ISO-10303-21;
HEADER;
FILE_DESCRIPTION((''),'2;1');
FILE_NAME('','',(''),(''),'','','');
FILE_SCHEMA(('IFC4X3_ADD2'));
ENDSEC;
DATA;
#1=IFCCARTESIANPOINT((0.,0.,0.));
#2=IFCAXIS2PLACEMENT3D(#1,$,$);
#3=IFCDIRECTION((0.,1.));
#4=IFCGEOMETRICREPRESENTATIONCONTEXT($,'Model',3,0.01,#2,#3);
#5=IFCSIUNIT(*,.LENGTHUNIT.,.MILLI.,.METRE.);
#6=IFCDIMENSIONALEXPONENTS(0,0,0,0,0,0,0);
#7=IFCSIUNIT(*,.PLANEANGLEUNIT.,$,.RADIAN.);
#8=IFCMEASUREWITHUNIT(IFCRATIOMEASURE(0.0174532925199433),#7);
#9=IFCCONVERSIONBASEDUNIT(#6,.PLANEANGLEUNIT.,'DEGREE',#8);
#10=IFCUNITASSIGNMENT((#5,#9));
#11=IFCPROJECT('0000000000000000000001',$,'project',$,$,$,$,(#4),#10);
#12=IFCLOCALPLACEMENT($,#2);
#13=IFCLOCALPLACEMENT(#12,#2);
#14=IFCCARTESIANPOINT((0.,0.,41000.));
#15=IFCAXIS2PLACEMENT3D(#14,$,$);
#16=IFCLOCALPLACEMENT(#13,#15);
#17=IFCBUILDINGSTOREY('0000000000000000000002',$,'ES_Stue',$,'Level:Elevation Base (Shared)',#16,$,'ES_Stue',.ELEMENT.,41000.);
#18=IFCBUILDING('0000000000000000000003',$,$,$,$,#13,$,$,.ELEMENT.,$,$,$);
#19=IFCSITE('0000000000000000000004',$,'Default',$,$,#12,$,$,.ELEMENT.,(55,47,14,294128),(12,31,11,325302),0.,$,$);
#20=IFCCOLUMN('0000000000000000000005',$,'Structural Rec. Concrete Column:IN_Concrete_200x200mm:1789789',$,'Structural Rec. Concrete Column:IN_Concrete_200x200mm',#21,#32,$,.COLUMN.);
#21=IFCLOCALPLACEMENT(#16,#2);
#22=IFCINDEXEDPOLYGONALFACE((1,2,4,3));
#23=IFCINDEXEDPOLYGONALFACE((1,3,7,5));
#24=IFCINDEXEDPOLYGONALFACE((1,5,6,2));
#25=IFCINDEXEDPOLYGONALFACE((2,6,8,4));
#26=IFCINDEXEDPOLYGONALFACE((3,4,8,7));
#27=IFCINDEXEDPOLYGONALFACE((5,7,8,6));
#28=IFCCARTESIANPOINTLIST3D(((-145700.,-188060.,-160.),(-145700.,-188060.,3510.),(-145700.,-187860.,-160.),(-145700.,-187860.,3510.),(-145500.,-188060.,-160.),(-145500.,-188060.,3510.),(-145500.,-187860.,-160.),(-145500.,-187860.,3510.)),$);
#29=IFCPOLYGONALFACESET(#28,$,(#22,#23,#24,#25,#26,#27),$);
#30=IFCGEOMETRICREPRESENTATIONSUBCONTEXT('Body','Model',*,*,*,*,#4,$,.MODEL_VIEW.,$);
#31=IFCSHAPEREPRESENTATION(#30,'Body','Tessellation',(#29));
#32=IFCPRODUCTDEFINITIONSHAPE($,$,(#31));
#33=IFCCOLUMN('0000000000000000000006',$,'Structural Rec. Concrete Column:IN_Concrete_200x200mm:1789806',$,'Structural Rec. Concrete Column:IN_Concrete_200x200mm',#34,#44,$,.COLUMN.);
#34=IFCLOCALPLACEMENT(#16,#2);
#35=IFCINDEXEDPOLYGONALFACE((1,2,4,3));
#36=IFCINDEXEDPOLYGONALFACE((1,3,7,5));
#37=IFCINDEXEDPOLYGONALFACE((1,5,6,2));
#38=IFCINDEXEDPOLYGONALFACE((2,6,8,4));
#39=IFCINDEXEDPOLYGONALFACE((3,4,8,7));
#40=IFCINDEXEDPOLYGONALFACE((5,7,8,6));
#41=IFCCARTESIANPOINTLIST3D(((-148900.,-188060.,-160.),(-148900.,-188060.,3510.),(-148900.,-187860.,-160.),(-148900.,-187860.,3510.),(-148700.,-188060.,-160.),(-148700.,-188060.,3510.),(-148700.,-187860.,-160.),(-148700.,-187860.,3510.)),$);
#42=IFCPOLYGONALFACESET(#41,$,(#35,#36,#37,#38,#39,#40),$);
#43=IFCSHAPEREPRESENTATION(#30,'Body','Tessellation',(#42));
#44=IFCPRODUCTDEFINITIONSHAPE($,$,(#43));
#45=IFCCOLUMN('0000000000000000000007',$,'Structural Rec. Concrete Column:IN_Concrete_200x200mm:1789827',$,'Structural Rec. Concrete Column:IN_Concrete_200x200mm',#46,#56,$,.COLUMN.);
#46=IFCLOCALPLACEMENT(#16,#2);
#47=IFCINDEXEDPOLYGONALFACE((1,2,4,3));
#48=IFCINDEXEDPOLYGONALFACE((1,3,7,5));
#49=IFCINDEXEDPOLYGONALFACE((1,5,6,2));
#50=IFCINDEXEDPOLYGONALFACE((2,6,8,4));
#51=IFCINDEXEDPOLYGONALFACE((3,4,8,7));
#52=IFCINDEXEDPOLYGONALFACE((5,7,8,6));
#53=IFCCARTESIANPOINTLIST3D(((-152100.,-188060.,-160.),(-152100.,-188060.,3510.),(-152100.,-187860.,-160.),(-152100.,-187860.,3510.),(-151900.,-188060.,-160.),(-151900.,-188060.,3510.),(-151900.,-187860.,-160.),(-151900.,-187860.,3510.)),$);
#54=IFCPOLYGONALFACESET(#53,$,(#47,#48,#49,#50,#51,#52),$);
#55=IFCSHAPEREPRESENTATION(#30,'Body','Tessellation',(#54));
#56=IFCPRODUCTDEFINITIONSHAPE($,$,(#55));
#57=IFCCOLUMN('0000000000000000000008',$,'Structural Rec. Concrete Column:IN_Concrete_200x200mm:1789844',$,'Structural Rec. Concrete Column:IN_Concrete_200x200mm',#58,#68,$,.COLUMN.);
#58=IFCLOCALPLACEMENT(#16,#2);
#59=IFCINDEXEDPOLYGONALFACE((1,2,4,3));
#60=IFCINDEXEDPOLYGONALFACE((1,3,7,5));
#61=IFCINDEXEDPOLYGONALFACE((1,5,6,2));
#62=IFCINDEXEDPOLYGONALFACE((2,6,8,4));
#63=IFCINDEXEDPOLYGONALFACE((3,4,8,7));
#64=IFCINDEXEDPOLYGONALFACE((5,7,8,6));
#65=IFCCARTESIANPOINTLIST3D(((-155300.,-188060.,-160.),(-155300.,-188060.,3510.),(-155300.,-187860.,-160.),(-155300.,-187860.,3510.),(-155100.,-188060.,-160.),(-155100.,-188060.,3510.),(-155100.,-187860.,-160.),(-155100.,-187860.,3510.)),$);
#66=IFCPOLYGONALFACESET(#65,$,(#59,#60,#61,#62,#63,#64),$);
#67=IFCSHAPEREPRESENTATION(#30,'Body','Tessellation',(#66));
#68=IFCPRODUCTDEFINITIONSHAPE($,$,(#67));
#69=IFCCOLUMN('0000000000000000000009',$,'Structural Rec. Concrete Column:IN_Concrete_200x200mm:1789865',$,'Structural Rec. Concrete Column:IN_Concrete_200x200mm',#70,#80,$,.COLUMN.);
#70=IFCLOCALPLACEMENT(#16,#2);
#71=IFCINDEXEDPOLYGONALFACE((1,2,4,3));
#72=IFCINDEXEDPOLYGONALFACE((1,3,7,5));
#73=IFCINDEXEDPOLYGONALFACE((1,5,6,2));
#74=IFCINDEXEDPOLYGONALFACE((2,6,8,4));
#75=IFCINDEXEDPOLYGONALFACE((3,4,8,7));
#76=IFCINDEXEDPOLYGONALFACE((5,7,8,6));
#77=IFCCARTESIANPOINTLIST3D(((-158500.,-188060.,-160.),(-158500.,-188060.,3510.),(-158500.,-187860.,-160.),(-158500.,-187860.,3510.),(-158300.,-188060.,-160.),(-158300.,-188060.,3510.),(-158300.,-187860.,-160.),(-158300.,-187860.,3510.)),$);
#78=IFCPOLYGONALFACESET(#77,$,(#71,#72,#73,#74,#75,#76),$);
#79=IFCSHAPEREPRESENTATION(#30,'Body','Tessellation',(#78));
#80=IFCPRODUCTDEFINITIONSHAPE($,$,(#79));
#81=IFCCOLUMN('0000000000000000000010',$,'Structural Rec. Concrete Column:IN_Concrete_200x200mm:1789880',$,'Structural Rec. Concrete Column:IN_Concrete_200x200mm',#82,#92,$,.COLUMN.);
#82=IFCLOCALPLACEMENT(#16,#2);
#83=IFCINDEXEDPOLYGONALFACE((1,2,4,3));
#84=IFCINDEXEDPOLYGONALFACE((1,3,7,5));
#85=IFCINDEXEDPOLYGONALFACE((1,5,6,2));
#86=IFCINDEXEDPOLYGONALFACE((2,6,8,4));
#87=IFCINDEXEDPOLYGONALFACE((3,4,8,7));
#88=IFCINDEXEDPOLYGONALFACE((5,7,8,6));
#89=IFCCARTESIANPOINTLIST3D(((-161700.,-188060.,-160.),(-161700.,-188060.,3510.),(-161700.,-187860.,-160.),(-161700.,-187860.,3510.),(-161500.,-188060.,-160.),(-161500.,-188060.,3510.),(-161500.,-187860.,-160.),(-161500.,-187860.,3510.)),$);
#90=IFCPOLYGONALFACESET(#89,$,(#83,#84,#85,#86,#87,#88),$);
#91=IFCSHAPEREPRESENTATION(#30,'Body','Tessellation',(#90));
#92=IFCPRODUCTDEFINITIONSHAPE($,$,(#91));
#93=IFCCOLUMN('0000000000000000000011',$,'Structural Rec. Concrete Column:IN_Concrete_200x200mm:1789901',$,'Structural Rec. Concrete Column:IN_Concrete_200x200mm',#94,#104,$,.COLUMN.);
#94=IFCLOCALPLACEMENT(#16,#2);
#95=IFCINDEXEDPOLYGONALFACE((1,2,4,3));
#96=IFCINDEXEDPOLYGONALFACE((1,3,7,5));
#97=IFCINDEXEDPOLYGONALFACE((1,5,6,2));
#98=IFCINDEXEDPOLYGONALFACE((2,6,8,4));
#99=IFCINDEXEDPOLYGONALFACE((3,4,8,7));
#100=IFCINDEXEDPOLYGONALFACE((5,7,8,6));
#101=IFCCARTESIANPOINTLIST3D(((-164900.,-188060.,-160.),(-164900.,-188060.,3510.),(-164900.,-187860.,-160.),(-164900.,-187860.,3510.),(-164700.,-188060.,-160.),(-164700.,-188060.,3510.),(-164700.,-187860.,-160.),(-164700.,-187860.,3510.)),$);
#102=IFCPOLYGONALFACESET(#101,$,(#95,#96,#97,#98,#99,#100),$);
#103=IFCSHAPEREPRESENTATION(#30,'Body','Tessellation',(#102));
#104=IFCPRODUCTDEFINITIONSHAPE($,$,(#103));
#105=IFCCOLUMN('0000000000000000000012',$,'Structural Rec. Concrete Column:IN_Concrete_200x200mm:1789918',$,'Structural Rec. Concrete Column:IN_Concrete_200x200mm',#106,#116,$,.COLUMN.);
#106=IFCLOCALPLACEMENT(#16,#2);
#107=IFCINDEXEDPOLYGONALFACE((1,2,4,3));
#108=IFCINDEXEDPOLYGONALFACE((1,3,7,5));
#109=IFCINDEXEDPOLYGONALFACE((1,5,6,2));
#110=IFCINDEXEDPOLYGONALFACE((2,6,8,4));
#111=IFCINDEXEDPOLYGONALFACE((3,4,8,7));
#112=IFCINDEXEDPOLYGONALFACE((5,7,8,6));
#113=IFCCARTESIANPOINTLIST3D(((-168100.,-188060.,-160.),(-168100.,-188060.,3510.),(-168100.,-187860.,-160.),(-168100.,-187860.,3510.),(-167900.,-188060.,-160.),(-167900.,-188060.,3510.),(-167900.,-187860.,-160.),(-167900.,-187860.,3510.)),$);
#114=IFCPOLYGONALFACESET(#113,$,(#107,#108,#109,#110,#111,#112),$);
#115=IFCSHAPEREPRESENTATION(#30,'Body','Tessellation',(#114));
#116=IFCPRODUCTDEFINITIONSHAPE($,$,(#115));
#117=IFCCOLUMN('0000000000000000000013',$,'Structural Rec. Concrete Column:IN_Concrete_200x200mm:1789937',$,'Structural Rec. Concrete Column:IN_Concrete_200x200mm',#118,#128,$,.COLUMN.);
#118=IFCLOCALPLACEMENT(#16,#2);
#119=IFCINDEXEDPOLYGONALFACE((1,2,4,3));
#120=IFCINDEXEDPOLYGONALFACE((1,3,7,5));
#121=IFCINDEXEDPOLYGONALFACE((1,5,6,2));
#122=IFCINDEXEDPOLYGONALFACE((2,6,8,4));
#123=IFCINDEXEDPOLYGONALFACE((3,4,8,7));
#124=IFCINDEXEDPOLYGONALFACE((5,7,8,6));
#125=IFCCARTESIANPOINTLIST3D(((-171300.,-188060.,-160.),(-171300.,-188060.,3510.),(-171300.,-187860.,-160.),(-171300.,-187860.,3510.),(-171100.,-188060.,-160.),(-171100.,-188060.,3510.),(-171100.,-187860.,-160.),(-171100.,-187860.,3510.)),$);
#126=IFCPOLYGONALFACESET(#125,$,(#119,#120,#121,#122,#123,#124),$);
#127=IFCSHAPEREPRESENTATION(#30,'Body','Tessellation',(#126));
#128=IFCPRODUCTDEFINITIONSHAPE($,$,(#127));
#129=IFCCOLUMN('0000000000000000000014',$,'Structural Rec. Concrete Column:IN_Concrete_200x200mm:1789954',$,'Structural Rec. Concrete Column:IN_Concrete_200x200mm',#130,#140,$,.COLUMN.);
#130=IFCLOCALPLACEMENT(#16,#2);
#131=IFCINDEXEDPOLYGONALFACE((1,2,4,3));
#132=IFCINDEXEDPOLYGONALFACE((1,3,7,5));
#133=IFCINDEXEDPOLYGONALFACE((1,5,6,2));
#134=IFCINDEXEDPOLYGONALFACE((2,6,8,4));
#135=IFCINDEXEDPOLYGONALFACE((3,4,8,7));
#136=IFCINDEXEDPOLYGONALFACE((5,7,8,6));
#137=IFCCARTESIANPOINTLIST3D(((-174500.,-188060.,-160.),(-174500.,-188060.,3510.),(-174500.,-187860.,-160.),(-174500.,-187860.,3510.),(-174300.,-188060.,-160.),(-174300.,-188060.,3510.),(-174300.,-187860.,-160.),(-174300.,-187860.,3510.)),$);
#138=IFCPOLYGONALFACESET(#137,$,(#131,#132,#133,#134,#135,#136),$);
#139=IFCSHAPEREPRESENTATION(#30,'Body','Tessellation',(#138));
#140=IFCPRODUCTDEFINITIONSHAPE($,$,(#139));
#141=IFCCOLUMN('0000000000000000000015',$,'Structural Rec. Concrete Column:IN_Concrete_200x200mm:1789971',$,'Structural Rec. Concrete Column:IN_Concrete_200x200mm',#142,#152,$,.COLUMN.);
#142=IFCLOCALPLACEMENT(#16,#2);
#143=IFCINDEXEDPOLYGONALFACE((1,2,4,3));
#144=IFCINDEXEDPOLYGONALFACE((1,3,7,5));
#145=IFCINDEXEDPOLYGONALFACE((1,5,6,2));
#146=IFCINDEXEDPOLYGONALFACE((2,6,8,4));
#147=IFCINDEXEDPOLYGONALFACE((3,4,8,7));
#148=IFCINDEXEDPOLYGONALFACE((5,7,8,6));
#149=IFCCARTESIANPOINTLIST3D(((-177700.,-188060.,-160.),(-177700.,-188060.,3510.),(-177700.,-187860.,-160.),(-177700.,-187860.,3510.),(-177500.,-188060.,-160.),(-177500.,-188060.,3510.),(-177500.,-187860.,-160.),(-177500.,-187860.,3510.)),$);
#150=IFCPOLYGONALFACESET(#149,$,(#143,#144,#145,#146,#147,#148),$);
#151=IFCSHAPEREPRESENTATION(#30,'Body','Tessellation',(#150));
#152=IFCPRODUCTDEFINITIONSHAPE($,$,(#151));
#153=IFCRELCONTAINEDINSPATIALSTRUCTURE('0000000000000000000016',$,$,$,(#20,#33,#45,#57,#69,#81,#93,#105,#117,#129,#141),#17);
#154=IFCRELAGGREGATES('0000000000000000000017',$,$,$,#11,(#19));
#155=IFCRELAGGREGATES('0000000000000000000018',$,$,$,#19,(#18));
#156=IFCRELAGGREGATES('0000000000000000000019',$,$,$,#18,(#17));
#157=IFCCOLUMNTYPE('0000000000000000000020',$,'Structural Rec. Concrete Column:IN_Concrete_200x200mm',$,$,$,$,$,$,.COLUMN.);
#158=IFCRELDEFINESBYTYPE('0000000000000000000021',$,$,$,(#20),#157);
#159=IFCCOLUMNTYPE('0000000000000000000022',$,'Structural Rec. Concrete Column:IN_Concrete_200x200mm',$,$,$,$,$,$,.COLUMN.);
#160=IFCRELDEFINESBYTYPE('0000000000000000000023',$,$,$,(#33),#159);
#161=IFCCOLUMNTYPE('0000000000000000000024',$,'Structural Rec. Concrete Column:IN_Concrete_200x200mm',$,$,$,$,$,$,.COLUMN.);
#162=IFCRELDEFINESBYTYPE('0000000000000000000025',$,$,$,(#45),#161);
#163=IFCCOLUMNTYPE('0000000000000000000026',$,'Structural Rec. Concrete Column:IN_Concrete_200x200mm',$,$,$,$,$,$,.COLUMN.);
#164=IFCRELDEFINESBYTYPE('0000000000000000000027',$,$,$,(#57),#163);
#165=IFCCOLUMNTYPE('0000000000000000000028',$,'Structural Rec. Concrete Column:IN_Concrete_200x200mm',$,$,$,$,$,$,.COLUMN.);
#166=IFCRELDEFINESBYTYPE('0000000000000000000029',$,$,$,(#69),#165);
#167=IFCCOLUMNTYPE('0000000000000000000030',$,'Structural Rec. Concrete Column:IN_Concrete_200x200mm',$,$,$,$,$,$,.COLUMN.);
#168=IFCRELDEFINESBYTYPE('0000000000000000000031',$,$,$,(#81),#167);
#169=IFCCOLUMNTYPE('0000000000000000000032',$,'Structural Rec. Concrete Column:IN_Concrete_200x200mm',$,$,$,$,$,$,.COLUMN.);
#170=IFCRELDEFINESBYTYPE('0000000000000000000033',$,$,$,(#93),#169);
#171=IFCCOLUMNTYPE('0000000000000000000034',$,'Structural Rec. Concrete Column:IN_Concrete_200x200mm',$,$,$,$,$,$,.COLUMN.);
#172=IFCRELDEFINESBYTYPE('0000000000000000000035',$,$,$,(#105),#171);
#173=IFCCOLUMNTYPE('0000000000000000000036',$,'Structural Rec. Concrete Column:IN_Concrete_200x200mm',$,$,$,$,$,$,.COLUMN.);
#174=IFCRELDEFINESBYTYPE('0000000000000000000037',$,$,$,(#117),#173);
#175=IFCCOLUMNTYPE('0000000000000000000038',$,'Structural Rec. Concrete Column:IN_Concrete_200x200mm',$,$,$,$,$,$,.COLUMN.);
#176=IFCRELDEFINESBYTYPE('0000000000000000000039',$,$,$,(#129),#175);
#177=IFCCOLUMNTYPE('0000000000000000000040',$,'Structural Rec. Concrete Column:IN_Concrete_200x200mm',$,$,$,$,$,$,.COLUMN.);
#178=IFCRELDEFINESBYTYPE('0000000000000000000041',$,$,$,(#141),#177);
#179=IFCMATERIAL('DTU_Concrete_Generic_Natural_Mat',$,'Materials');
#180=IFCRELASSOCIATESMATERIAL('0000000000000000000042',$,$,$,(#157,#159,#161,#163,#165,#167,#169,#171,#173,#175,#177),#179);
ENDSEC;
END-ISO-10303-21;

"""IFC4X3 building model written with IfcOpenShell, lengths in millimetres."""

from ifc_helpers import new_model, entity, si_unit, converted_unit, direction, frame, frame_2d, origin, origin_2d_with_axis, place, context, subcontext, project, spatial, rectangle, extrude, source, transform, mapped, material, material_profile, profile_set, type_object, type_shapes, element, save


model = new_model("IFC4X3")

# Units and contexts
model_context = context("Model", 3, precision=0.01, world=origin(), true_north=direction((0.0, 1.0)))
body_context = subcontext(model_context, "Body", "Model", "MODEL_VIEW")
ifc_project = project(units=[si_unit("LENGTHUNIT", "METRE", prefix="MILLI"), converted_unit("PLANEANGLEUNIT", "DEGREE", entity("IfcRatioMeasure", 0.0174532925199433), si_unit("PLANEANGLEUNIT", "RADIAN"), dimensions=[0, 0, 0, 0, 0, 0, 0])], contexts=[model_context])

# Site, building, storey
site_placement = place(None, origin())
site = spatial("IfcSite", under=ifc_project, at=site_placement, Name="Default", CompositionType="ELEMENT", RefLatitude=(55, 47, 14, 294128), RefLongitude=(12, 31, 11, 325302), RefElevation=0.0)
building_placement = place(site_placement, origin())
building = spatial("IfcBuilding", under=site, at=building_placement, CompositionType="ELEMENT")
storey_placement = place(building_placement, frame((0.0, 0.0, 41000.0)))
storey = spatial("IfcBuildingStorey", under=building, at=storey_placement, Name="ES_Stue", ObjectType="Level:Elevation Base (Shared)", LongName="ES_Stue", CompositionType="ELEMENT", Elevation=41000.0)

# Columns
ifc_material = material(Name="DTU_Concrete_Generic_Natural_Mat", Category="Materials")
ifc_material_profile_1 = material_profile(ifc_material, rectangle(XDim=200.0, YDim=200.0, at=origin_2d_with_axis()), Name="IN_Concrete_200x200mm")
ifc_profile_set_1 = profile_set([ifc_material_profile_1], Name="IN_Concrete_200x200mm")
column_type_1 = type_object("IfcColumnType", Name="Structural Rec. Concrete Column:IN_Concrete_200x200mm", PredefinedType="COLUMN", material=ifc_profile_set_1)
shared_shape_1 = source(origin(), body_context, "Body", "SweptSolid", [
    extrude(rectangle(XDim=200.0, YDim=200.0, at=frame_2d((0.0, 0.0), x_axis=(1.0, 0.0))), frame((-145600.0, -187960.0, 40840.0), z_axis=(0.0, 0.0, 1.0), x_axis=(0.0, -1.0, 0.0)), (0.0, 0.0, 1.0), 3670.0),
])
type_shapes(column_type_1, [shared_shape_1])
column_1_placement = place(storey_placement, frame((0.0, 0.0, -41000.0)))
element("IfcColumn", 1, at=column_1_placement, inside=storey, type_object=column_type_1, Name="Structural Rec. Concrete Column:IN_Concrete_200x200mm:1789789", ObjectType="Structural Rec. Concrete Column:IN_Concrete_200x200mm", PredefinedType="COLUMN", context=body_context, shape_type="MappedRepresentation", body=[
    mapped(shared_shape_1, transform((0.0, 0.0, 0.0), scale=1.0)),
])
column_type_2 = type_object("IfcColumnType", Name="Structural Rec. Concrete Column:IN_Concrete_200x200mm", PredefinedType="COLUMN", material=ifc_profile_set_1)
shared_shape_2 = source(origin(), body_context, "Body", "SweptSolid", [
    extrude(rectangle(XDim=200.0, YDim=200.0, at=origin_2d_with_axis()), frame((-148800.0, -187960.0, 40840.0), z_axis=(0.0, 0.0, 1.0), x_axis=(0.0, -1.0, 0.0)), (0.0, 0.0, 1.0), 3670.0),
])
type_shapes(column_type_2, [shared_shape_2])
column_2_placement = place(storey_placement, frame((0.0, 0.0, -41000.0)))
element("IfcColumn", 2, at=column_2_placement, inside=storey, type_object=column_type_2, Name="Structural Rec. Concrete Column:IN_Concrete_200x200mm:1789806", ObjectType="Structural Rec. Concrete Column:IN_Concrete_200x200mm", PredefinedType="COLUMN", context=body_context, shape_type="MappedRepresentation", body=[
    mapped(shared_shape_2, transform((0.0, 0.0, 0.0), scale=1.0)),
])
column_type_3 = type_object("IfcColumnType", Name="Structural Rec. Concrete Column:IN_Concrete_200x200mm", PredefinedType="COLUMN", material=ifc_profile_set_1)
shared_shape_3 = source(origin(), body_context, "Body", "SweptSolid", [
    extrude(rectangle(XDim=200.0, YDim=200.0, at=frame_2d((0.0, 0.0), x_axis=(1.0, 0.0))), frame((-152000.0, -187960.0, 40840.0), z_axis=(0.0, 0.0, 1.0), x_axis=(0.0, -1.0, 0.0)), (0.0, 0.0, 1.0), 3670.0),
])
type_shapes(column_type_3, [shared_shape_3])
column_3_placement = place(storey_placement, frame((0.0, 0.0, -41000.0)))
element("IfcColumn", 3, at=column_3_placement, inside=storey, type_object=column_type_3, Name="Structural Rec. Concrete Column:IN_Concrete_200x200mm:1789827", ObjectType="Structural Rec. Concrete Column:IN_Concrete_200x200mm", PredefinedType="COLUMN", context=body_context, shape_type="MappedRepresentation", body=[
    mapped(shared_shape_3, transform((0.0, 0.0, 0.0), scale=1.0)),
])
column_type_4 = type_object("IfcColumnType", Name="Structural Rec. Concrete Column:IN_Concrete_200x200mm", PredefinedType="COLUMN", material=ifc_profile_set_1)
shared_shape_4 = source(origin(), body_context, "Body", "SweptSolid", [
    extrude(rectangle(XDim=200.0, YDim=200.0, at=origin_2d_with_axis()), frame((-155200.0, -187960.0, 40840.0), z_axis=(0.0, 0.0, 1.0), x_axis=(0.0, -1.0, 0.0)), (0.0, 0.0, 1.0), 3670.0),
])
type_shapes(column_type_4, [shared_shape_4])
column_4_placement = place(storey_placement, frame((0.0, 0.0, -41000.0)))
element("IfcColumn", 4, at=column_4_placement, inside=storey, type_object=column_type_4, Name="Structural Rec. Concrete Column:IN_Concrete_200x200mm:1789844", ObjectType="Structural Rec. Concrete Column:IN_Concrete_200x200mm", PredefinedType="COLUMN", context=body_context, shape_type="MappedRepresentation", body=[
    mapped(shared_shape_4, transform((0.0, 0.0, 0.0), scale=1.0)),
])
column_type_5 = type_object("IfcColumnType", Name="Structural Rec. Concrete Column:IN_Concrete_200x200mm", PredefinedType="COLUMN", material=ifc_profile_set_1)
shared_shape_5 = source(origin(), body_context, "Body", "SweptSolid", [
    extrude(rectangle(XDim=200.0, YDim=200.0, at=origin_2d_with_axis()), frame((-158400.0, -187960.0, 40840.0), z_axis=(0.0, 0.0, 1.0), x_axis=(0.0, -1.0, 0.0)), (0.0, 0.0, 1.0), 3670.0),
])
type_shapes(column_type_5, [shared_shape_5])
column_5_placement = place(storey_placement, frame((0.0, 0.0, -41000.0)))
element("IfcColumn", 5, at=column_5_placement, inside=storey, type_object=column_type_5, Name="Structural Rec. Concrete Column:IN_Concrete_200x200mm:1789865", ObjectType="Structural Rec. Concrete Column:IN_Concrete_200x200mm", PredefinedType="COLUMN", context=body_context, shape_type="MappedRepresentation", body=[
    mapped(shared_shape_5, transform((0.0, 0.0, 0.0), scale=1.0)),
])
column_type_6 = type_object("IfcColumnType", Name="Structural Rec. Concrete Column:IN_Concrete_200x200mm", PredefinedType="COLUMN", material=ifc_profile_set_1)
shared_shape_6 = source(origin(), body_context, "Body", "SweptSolid", [
    extrude(rectangle(XDim=200.0, YDim=200.0, at=origin_2d_with_axis()), frame((-161600.0, -187960.0, 40840.0), z_axis=(0.0, 0.0, 1.0), x_axis=(0.0, -1.0, 0.0)), (0.0, 0.0, 1.0), 3670.0),
])
type_shapes(column_type_6, [shared_shape_6])
column_6_placement = place(storey_placement, frame((0.0, 0.0, -41000.0)))
element("IfcColumn", 6, at=column_6_placement, inside=storey, type_object=column_type_6, Name="Structural Rec. Concrete Column:IN_Concrete_200x200mm:1789880", ObjectType="Structural Rec. Concrete Column:IN_Concrete_200x200mm", PredefinedType="COLUMN", context=body_context, shape_type="MappedRepresentation", body=[
    mapped(shared_shape_6, transform((0.0, 0.0, 0.0), scale=1.0)),
])
column_type_7 = type_object("IfcColumnType", Name="Structural Rec. Concrete Column:IN_Concrete_200x200mm", PredefinedType="COLUMN", material=ifc_profile_set_1)
shared_shape_7 = source(origin(), body_context, "Body", "SweptSolid", [
    extrude(rectangle(XDim=200.0, YDim=200.0, at=origin_2d_with_axis()), frame((-164800.0, -187960.0, 40840.0), z_axis=(0.0, 0.0, 1.0), x_axis=(0.0, -1.0, 0.0)), (0.0, 0.0, 1.0), 3670.0),
])
type_shapes(column_type_7, [shared_shape_7])
column_7_placement = place(storey_placement, frame((0.0, 0.0, -41000.0)))
element("IfcColumn", 7, at=column_7_placement, inside=storey, type_object=column_type_7, Name="Structural Rec. Concrete Column:IN_Concrete_200x200mm:1789901", ObjectType="Structural Rec. Concrete Column:IN_Concrete_200x200mm", PredefinedType="COLUMN", context=body_context, shape_type="MappedRepresentation", body=[
    mapped(shared_shape_7, transform((0.0, 0.0, 0.0), scale=1.0)),
])
column_type_8 = type_object("IfcColumnType", Name="Structural Rec. Concrete Column:IN_Concrete_200x200mm", PredefinedType="COLUMN", material=ifc_profile_set_1)
shared_shape_8 = source(origin(), body_context, "Body", "SweptSolid", [
    extrude(rectangle(XDim=200.0, YDim=200.0, at=origin_2d_with_axis()), frame((-168000.0, -187960.0, 40840.0), z_axis=(0.0, 0.0, 1.0), x_axis=(0.0, -1.0, 0.0)), (0.0, 0.0, 1.0), 3670.0),
])
type_shapes(column_type_8, [shared_shape_8])
column_8_placement = place(storey_placement, frame((0.0, 0.0, -41000.0)))
element("IfcColumn", 8, at=column_8_placement, inside=storey, type_object=column_type_8, Name="Structural Rec. Concrete Column:IN_Concrete_200x200mm:1789918", ObjectType="Structural Rec. Concrete Column:IN_Concrete_200x200mm", PredefinedType="COLUMN", context=body_context, shape_type="MappedRepresentation", body=[
    mapped(shared_shape_8, transform((0.0, 0.0, 0.0), scale=1.0)),
])
column_type_9 = type_object("IfcColumnType", Name="Structural Rec. Concrete Column:IN_Concrete_200x200mm", PredefinedType="COLUMN", material=ifc_profile_set_1)
shared_shape_9 = source(origin(), body_context, "Body", "SweptSolid", [
    extrude(rectangle(XDim=200.0, YDim=200.0, at=origin_2d_with_axis()), frame((-171200.0, -187960.0, 40840.0), z_axis=(0.0, 0.0, 1.0), x_axis=(0.0, -1.0, 0.0)), (0.0, 0.0, 1.0), 3670.0),
])
type_shapes(column_type_9, [shared_shape_9])
column_9_placement = place(storey_placement, frame((0.0, 0.0, -41000.0)))
element("IfcColumn", 9, at=column_9_placement, inside=storey, type_object=column_type_9, Name="Structural Rec. Concrete Column:IN_Concrete_200x200mm:1789937", ObjectType="Structural Rec. Concrete Column:IN_Concrete_200x200mm", PredefinedType="COLUMN", context=body_context, shape_type="MappedRepresentation", body=[
    mapped(shared_shape_9, transform((0.0, 0.0, 0.0), scale=1.0)),
])
column_type_10 = type_object("IfcColumnType", Name="Structural Rec. Concrete Column:IN_Concrete_200x200mm", PredefinedType="COLUMN", material=ifc_profile_set_1)
shared_shape_10 = source(origin(), body_context, "Body", "SweptSolid", [
    extrude(rectangle(XDim=200.0, YDim=200.0, at=origin_2d_with_axis()), frame((-174400.0, -187960.0, 40840.0), z_axis=(0.0, 0.0, 1.0), x_axis=(0.0, -1.0, 0.0)), (0.0, 0.0, 1.0), 3670.0),
])
type_shapes(column_type_10, [shared_shape_10])
column_10_placement = place(storey_placement, frame((0.0, 0.0, -41000.0)))
element("IfcColumn", 10, at=column_10_placement, inside=storey, type_object=column_type_10, Name="Structural Rec. Concrete Column:IN_Concrete_200x200mm:1789954", ObjectType="Structural Rec. Concrete Column:IN_Concrete_200x200mm", PredefinedType="COLUMN", context=body_context, shape_type="MappedRepresentation", body=[
    mapped(shared_shape_10, transform((0.0, 0.0, 0.0), scale=1.0)),
])
column_type_11 = type_object("IfcColumnType", Name="Structural Rec. Concrete Column:IN_Concrete_200x200mm", PredefinedType="COLUMN", material=ifc_profile_set_1)
shared_shape_11 = source(origin(), body_context, "Body", "SweptSolid", [
    extrude(rectangle(XDim=200.0, YDim=200.0, at=origin_2d_with_axis()), frame((-177600.0, -187960.0, 40840.0), z_axis=(0.0, 0.0, 1.0), x_axis=(0.0, -1.0, 0.0)), (0.0, 0.0, 1.0), 3670.0),
])
type_shapes(column_type_11, [shared_shape_11])
column_11_placement = place(storey_placement, frame((0.0, 0.0, -41000.0)))
element("IfcColumn", 11, at=column_11_placement, inside=storey, type_object=column_type_11, Name="Structural Rec. Concrete Column:IN_Concrete_200x200mm:1789971", ObjectType="Structural Rec. Concrete Column:IN_Concrete_200x200mm", PredefinedType="COLUMN", context=body_context, shape_type="MappedRepresentation", body=[
    mapped(shared_shape_11, transform((0.0, 0.0, 0.0), scale=1.0)),
])

save(model, "model.ifc")
